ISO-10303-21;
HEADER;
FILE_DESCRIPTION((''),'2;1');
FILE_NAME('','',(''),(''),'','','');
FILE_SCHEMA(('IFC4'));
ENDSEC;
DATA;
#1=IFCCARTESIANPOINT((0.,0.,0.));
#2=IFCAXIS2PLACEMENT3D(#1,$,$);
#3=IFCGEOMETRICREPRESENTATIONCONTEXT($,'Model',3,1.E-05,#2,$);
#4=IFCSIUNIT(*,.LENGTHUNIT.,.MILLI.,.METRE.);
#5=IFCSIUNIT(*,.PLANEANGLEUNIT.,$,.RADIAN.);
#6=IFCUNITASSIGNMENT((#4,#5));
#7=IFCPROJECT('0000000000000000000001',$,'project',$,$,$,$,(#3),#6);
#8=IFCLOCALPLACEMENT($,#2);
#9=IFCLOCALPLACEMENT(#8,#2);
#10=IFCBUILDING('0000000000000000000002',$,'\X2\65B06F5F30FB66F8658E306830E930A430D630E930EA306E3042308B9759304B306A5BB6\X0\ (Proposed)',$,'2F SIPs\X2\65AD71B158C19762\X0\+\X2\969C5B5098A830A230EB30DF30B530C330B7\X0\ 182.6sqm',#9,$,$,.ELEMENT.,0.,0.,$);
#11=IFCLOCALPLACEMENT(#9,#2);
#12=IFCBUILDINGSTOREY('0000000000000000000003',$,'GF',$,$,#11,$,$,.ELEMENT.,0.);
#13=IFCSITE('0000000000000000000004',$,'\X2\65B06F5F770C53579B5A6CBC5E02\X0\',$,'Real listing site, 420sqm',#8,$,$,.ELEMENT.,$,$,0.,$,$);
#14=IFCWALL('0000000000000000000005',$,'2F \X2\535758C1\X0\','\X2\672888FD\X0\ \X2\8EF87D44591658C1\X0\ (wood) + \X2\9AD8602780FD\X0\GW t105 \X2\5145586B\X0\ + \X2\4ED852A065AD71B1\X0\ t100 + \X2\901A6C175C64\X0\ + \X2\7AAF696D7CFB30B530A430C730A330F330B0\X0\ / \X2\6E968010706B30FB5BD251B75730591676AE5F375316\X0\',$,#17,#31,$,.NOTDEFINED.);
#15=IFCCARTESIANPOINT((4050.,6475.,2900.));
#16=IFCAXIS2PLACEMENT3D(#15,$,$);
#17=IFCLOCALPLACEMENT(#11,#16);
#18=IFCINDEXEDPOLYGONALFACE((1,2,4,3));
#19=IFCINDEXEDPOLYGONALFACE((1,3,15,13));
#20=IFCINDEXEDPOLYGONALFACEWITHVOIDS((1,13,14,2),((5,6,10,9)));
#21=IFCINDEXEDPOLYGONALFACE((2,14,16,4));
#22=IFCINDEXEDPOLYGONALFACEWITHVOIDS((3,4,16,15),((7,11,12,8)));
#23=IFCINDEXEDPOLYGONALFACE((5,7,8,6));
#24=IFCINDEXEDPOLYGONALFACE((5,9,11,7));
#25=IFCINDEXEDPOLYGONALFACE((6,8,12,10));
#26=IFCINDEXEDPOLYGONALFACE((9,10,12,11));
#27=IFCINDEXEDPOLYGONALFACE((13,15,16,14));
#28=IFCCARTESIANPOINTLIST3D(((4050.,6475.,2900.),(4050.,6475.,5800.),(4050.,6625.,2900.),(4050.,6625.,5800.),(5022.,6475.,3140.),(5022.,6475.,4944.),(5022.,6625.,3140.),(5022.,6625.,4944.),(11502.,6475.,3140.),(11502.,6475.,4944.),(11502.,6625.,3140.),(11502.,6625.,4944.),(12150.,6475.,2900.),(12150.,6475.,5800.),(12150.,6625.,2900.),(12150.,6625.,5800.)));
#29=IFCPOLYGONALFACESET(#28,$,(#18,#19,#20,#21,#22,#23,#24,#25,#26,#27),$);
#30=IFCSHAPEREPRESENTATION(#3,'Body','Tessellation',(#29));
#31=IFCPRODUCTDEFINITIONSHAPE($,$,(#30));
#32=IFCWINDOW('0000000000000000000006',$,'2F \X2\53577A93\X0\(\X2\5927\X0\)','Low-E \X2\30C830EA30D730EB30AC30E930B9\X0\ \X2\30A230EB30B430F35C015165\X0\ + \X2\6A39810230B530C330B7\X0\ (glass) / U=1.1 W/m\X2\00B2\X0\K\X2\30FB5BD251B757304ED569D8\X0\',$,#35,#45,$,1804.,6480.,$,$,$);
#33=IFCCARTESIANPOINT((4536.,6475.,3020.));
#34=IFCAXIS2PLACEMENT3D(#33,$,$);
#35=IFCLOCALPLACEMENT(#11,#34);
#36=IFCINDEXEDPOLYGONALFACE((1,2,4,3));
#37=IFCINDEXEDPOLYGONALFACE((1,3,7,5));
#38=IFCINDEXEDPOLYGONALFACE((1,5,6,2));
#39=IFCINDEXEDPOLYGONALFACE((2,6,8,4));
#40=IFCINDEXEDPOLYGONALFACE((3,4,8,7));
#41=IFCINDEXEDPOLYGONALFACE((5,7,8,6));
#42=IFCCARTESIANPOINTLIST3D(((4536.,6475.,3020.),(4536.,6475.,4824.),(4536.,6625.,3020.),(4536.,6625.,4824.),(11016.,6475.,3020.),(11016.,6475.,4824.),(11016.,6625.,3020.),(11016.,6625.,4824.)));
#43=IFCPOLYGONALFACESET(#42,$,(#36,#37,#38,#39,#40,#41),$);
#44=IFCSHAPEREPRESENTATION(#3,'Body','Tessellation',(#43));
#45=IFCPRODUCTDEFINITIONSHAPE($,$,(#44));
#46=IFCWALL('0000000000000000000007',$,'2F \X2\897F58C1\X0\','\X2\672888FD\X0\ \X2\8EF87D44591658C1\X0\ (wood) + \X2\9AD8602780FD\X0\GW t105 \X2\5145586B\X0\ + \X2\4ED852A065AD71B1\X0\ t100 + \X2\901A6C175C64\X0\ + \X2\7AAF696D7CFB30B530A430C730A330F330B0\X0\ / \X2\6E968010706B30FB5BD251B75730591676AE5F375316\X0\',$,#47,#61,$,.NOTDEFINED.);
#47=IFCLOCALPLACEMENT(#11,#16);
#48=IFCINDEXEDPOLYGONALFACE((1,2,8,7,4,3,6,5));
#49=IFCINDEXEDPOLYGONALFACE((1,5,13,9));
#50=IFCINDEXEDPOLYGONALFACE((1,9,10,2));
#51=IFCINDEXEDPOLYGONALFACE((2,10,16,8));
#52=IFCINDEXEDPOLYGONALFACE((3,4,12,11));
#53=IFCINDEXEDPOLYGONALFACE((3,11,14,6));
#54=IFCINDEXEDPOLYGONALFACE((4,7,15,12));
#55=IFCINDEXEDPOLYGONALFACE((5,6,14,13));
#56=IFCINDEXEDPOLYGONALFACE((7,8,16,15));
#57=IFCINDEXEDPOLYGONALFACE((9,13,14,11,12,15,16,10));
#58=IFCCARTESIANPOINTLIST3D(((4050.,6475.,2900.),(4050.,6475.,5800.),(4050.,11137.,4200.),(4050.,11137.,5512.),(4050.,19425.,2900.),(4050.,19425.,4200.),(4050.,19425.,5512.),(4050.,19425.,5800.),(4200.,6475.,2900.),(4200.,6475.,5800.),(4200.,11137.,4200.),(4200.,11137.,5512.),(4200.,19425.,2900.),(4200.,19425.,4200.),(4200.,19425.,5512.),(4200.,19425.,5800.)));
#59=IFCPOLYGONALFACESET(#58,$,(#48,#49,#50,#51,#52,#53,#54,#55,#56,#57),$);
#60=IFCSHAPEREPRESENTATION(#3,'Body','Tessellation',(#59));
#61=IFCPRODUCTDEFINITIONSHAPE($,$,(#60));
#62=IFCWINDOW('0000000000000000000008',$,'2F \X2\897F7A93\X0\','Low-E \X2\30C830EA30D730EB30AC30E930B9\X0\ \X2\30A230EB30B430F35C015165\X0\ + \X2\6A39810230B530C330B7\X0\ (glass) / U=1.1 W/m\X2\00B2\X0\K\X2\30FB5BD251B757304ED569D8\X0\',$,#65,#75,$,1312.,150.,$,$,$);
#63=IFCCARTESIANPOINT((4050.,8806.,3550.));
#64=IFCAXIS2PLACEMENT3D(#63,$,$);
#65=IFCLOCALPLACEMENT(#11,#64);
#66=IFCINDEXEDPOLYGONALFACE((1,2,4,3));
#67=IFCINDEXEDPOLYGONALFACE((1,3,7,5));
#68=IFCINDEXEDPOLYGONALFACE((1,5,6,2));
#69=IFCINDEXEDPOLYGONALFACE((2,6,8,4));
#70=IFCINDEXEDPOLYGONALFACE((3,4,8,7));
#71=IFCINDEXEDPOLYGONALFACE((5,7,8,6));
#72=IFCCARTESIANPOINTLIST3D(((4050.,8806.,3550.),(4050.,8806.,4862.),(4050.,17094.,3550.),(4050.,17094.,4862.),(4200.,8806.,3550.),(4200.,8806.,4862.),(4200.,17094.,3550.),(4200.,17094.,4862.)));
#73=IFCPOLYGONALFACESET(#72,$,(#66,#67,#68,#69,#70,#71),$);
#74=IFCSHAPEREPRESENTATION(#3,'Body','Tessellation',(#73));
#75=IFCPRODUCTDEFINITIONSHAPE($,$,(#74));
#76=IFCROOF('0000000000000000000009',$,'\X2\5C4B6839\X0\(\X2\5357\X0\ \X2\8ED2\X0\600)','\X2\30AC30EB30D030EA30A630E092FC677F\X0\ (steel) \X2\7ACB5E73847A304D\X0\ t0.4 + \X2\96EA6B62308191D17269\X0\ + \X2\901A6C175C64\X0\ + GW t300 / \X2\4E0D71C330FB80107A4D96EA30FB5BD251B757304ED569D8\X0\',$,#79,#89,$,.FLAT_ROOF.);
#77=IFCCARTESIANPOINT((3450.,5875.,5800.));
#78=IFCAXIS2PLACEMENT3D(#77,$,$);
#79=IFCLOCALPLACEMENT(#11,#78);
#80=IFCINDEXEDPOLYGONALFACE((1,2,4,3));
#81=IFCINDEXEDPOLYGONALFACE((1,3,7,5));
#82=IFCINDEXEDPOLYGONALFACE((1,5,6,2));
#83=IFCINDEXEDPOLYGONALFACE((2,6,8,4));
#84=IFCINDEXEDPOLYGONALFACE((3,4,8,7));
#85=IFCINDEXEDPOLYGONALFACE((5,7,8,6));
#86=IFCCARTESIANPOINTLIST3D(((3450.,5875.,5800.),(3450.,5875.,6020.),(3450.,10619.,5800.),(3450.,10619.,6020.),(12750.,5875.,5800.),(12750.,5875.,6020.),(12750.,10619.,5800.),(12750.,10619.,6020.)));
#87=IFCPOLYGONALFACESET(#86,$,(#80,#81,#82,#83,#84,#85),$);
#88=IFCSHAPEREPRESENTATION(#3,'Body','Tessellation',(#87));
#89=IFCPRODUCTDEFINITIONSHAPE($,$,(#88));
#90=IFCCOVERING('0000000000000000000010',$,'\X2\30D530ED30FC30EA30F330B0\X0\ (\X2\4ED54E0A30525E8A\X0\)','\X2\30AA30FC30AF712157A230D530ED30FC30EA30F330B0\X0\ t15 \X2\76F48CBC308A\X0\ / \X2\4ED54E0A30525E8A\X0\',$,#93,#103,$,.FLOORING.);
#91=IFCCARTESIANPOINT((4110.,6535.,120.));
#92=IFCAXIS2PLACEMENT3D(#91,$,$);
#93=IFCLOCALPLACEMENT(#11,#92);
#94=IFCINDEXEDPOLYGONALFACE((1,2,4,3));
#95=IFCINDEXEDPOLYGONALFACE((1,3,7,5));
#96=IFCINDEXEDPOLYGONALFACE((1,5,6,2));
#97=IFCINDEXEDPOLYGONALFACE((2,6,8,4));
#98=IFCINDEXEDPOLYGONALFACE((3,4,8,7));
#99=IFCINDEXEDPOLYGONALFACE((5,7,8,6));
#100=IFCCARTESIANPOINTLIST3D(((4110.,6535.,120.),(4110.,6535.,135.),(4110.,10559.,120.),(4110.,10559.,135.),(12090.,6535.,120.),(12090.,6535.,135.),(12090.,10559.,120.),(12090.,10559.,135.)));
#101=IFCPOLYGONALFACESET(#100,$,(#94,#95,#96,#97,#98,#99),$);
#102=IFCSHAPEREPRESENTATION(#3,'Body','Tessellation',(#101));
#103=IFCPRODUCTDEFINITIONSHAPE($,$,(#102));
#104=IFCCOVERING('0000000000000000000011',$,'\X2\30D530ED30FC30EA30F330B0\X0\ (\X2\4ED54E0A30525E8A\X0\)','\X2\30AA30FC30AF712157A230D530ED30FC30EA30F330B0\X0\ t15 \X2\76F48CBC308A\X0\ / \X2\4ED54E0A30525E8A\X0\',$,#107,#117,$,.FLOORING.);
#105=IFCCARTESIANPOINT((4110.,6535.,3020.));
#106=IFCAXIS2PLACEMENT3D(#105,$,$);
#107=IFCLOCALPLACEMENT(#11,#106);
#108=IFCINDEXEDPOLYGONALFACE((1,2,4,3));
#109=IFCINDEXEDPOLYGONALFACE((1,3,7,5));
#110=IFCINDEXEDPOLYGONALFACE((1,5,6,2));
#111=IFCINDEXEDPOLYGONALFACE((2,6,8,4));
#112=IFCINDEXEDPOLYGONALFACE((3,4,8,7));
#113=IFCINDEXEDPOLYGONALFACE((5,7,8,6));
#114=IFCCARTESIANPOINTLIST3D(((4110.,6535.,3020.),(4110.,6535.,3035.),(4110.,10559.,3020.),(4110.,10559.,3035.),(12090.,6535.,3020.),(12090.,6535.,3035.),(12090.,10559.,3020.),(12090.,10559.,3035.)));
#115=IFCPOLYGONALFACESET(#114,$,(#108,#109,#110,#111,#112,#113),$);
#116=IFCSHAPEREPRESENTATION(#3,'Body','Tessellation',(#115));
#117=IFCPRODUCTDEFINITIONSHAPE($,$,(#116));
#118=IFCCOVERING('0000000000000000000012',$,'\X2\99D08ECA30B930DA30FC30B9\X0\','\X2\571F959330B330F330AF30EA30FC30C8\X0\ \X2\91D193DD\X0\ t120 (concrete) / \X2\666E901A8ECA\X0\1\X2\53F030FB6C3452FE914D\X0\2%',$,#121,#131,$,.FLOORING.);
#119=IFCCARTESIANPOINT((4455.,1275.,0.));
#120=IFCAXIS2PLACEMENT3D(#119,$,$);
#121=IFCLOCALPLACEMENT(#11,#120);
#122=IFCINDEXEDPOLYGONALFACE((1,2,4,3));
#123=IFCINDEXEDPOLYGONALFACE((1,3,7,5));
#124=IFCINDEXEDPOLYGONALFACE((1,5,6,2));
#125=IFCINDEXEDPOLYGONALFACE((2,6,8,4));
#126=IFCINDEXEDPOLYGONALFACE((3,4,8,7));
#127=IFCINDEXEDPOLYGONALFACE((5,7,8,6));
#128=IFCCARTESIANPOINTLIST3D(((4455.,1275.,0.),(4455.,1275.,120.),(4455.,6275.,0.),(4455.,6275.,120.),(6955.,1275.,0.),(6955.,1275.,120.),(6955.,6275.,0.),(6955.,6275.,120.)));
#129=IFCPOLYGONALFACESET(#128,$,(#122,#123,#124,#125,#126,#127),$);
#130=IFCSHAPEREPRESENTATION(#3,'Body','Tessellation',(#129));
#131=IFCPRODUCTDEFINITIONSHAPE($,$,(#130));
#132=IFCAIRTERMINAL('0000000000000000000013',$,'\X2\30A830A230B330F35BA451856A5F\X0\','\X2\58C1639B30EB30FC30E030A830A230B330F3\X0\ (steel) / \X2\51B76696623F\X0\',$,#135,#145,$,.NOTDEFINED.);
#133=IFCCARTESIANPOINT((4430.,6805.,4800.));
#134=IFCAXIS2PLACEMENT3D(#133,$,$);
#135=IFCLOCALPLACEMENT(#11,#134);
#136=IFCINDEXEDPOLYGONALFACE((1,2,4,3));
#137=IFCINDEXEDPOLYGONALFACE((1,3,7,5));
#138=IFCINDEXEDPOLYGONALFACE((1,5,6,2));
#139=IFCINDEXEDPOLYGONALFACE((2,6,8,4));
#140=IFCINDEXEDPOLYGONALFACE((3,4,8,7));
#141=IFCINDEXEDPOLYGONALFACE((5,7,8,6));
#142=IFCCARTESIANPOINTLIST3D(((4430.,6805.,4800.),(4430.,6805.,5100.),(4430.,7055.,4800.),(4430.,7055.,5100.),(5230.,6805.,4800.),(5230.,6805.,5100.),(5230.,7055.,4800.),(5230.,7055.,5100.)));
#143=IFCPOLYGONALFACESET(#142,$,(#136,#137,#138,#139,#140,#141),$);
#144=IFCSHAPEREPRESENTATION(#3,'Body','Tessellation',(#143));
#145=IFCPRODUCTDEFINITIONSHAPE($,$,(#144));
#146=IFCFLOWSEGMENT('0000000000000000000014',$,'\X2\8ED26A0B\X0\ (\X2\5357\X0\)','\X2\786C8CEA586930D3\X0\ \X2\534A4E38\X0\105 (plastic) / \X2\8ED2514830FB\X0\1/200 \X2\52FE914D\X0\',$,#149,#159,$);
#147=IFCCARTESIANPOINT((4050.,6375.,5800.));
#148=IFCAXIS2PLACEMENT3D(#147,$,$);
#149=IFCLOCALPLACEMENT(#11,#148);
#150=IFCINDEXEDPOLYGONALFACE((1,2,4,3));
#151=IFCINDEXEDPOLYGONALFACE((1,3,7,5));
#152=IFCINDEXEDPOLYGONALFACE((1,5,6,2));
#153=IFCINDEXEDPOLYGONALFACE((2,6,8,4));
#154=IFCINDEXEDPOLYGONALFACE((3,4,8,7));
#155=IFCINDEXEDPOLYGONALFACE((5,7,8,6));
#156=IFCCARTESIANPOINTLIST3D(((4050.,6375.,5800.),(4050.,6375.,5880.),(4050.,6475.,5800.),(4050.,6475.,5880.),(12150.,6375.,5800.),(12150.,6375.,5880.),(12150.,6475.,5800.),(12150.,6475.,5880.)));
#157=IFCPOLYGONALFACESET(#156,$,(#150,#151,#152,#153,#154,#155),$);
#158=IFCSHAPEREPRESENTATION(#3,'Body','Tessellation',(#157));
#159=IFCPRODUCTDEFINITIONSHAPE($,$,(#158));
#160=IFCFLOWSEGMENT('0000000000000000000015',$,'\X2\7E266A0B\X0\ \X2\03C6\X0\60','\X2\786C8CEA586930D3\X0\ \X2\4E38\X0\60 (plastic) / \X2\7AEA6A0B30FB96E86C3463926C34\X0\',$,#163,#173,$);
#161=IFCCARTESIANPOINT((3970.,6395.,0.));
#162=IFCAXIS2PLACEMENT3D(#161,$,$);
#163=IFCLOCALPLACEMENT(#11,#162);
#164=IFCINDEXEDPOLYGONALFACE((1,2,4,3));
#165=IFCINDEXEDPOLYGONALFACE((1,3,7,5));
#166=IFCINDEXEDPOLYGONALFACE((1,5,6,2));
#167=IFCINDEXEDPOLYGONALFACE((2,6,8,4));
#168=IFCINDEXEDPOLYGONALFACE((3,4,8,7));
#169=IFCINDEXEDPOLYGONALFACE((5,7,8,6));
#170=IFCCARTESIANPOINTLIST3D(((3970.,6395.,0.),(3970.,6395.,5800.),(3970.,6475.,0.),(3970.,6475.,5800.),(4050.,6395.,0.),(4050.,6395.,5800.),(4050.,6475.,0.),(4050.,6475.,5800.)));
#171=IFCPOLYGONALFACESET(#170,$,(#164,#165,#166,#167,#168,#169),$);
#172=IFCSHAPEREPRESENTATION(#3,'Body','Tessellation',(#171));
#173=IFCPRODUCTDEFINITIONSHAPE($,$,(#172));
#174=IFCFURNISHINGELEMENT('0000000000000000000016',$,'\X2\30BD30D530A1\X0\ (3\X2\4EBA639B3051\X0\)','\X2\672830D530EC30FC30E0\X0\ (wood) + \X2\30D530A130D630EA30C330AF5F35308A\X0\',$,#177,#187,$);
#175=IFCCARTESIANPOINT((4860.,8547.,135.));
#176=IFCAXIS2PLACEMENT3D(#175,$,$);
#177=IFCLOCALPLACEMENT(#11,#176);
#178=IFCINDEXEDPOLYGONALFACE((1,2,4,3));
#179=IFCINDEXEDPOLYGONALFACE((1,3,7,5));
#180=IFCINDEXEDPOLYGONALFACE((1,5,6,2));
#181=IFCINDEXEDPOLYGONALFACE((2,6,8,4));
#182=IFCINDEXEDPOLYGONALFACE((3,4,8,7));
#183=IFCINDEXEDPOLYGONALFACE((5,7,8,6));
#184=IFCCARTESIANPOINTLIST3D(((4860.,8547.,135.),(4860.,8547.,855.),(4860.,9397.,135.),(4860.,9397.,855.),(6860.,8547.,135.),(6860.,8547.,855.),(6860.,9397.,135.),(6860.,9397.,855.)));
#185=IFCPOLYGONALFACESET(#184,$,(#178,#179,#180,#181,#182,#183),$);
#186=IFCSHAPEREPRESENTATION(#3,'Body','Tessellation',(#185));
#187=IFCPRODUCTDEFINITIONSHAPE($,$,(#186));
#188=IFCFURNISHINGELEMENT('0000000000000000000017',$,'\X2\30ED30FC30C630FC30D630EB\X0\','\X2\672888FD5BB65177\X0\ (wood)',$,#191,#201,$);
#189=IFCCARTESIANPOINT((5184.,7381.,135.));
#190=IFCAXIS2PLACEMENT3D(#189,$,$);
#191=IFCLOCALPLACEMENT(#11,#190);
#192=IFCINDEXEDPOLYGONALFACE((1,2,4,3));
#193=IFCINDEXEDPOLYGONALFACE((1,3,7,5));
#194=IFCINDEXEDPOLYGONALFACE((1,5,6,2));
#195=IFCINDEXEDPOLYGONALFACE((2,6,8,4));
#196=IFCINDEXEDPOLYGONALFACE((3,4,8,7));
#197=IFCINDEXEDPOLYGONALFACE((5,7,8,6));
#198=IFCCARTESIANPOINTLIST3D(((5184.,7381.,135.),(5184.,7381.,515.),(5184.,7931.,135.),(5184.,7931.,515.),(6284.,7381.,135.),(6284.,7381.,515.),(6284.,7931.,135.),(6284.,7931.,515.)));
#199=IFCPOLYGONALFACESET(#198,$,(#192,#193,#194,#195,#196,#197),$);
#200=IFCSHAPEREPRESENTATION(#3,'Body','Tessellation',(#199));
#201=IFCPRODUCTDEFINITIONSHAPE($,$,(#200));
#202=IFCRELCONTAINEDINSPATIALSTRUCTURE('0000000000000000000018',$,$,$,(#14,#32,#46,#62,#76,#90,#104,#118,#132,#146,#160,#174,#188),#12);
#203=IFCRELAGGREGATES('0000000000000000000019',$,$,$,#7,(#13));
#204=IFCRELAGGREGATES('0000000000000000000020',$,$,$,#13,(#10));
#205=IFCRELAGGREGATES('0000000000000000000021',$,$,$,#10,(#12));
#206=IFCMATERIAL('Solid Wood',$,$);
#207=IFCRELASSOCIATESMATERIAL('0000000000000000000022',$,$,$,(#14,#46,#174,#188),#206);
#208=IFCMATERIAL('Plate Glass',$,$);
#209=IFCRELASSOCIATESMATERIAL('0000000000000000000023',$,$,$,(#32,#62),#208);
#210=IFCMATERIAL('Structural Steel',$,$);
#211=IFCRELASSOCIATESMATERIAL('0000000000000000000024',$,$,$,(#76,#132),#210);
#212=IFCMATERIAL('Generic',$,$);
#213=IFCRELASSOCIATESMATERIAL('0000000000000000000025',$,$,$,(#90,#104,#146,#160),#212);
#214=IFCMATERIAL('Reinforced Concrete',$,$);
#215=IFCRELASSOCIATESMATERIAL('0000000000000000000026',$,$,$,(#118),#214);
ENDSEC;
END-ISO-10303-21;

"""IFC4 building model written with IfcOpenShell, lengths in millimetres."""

from ifc_helpers import new_model, si_unit, frame, frame_2d, origin, place, context, project, spatial, rectangle, extrude, material, element, fill, save


model = new_model("IFC4")

# Units and contexts
model_context = context("Model", 3, precision=1e-05, world=origin())
ifc_project = project(units=[si_unit("LENGTHUNIT", "METRE", prefix="MILLI"), si_unit("PLANEANGLEUNIT", "RADIAN")], contexts=[model_context])

# Site, building, storey
site_placement = place(None, origin())
site = spatial("IfcSite", under=ifc_project, at=site_placement, Name="新潟県南魚沼市", ObjectType="Real listing site, 420sqm", CompositionType="ELEMENT", RefElevation=0.0)
building_placement = place(site_placement, origin())
building = spatial("IfcBuilding", under=site, at=building_placement, Name="新潟・書斎とライブラリのある静かな家 (Proposed)", ObjectType="2F SIPs断熱壁面+障子風アルミサッシ 182.6sqm", CompositionType="ELEMENT", ElevationOfRefHeight=0.0, ElevationOfTerrain=0.0)
storey_placement = place(building_placement, origin())
storey = spatial("IfcBuildingStorey", under=building, at=storey_placement, Name="GF", CompositionType="ELEMENT", Elevation=0.0)

# Shared definitions
ifc_material_1 = material(Name="Solid Wood")

# Shared definitions
ifc_material_2 = material(Name="Reinforced Concrete")

# Shared definitions
ifc_material_3 = material(Name="Plate Glass")

# Walls, openings, windows
wall_1_placement = place(storey_placement, frame((4050.0, 6475.0, 2900.0)))
wall_1 = element("IfcWall", 1, at=wall_1_placement, inside=storey, material=ifc_material_1, Name="2F 南壁", Description="木製 軸組外壁 (wood) + 高性能GW t105 充填 + 付加断熱 t100 + 通気層 + 窯業系サイディング / 準耐火・寒冷地外皮強化", PredefinedType="NOTDEFINED", context=model_context, shape_type="SweptSolid", body=[
    extrude(rectangle(XDim=8100.0, YDim=150.0, at=frame_2d((4050.0, 75.0))), frame((4050.0, 6475.0, 2900.0)), (0.0, 0.0, 1.0), 2900.0),
])
opening_1_placement = place(storey_placement, frame((4536.0, 6475.0, 3020.0)))
opening_1 = element("IfcOpeningElement", 2, at=opening_1_placement, cuts=wall_1, PredefinedType="NOTDEFINED", context=model_context, shape_type="SweptSolid", body=[
    extrude(rectangle(XDim=6480.0, YDim=150.0, at=frame_2d((3240.0, 75.0))), frame((4536.0, 6475.0, 3020.0)), (0.0, 0.0, 1.0), 1804.0),
])
window_1_placement = place(storey_placement, frame((4536.0, 6475.0, 3020.0)))
window_1 = element("IfcWindow", 3, at=window_1_placement, inside=storey, material=ifc_material_3, Name="2F 南窓(大)", Description="Low-E トリプルガラス アルゴン封入 + 樹脂サッシ (glass) / U=1.1 W/m²K・寒冷地仕様", OverallHeight=1804.0, OverallWidth=6480.0, context=model_context, shape_type="SweptSolid", body=[
    extrude(rectangle(XDim=6480.0, YDim=150.0, at=frame_2d((3240.0, 75.0))), frame((4536.0, 6475.0, 3020.0)), (0.0, 0.0, 1.0), 1804.0),
])
fill(opening_1, window_1)
wall_2_placement = place(storey_placement, frame((4050.0, 6475.0, 2900.0)))
wall_2 = element("IfcWall", 4, at=wall_2_placement, inside=storey, material=ifc_material_1, Name="2F 西壁", Description="木製 軸組外壁 (wood) + 高性能GW t105 充填 + 付加断熱 t100 + 通気層 + 窯業系サイディング / 準耐火・寒冷地外皮強化", PredefinedType="NOTDEFINED", context=model_context, shape_type="SweptSolid", body=[
    extrude(rectangle(XDim=150.0, YDim=12950.0, at=frame_2d((75.0, 6475.0))), frame((4050.0, 6475.0, 2900.0)), (0.0, 0.0, 1.0), 2900.0),
])
opening_2_placement = place(storey_placement, frame((4050.0, 8806.0, 3550.0)))
opening_2 = element("IfcOpeningElement", 5, at=opening_2_placement, cuts=wall_2, PredefinedType="NOTDEFINED", context=model_context, shape_type="SweptSolid", body=[
    extrude(rectangle(XDim=150.0, YDim=8288.0, at=frame_2d((75.0, 4144.0))), frame((4050.0, 8806.0, 3550.0)), (0.0, 0.0, 1.0), 1312.0),
])
window_2_placement = place(storey_placement, frame((4050.0, 8806.0, 3550.0)))
window_2 = element("IfcWindow", 6, at=window_2_placement, inside=storey, material=ifc_material_3, Name="2F 西窓", Description="Low-E トリプルガラス アルゴン封入 + 樹脂サッシ (glass) / U=1.1 W/m²K・寒冷地仕様", OverallHeight=1312.0, OverallWidth=150.0, context=model_context, shape_type="SweptSolid", body=[
    extrude(rectangle(XDim=150.0, YDim=8288.0, at=frame_2d((75.0, 4144.0))), frame((4050.0, 8806.0, 3550.0)), (0.0, 0.0, 1.0), 1312.0),
])
fill(opening_2, window_2)

# Roof
ifc_material_4 = material(Name="Structural Steel")
for number, where, name in (
    (7, (3450.0, 5875.0, 5800.0), "屋根(南 軒600)"),
):
    element("IfcRoof", number, at=place(storey_placement, frame(where)), inside=storey, material=ifc_material_4, Name=name, Description="ガルバリウム鋼板 (steel) 立平葺き t0.4 + 雪止め金物 + 通気層 + GW t300 / 不燃・耐積雪・寒冷地仕様", PredefinedType="FLAT_ROOF", context=model_context, shape_type="SweptSolid", body=[
        extrude(rectangle(XDim=9300.0, YDim=4744.0, at=frame_2d((4650.0, 2372.0))), frame((3450.0, 5875.0, 5800.0)), (0.0, 0.0, 1.0), 220.0),
    ])

# Coverings
ifc_material_5 = material(Name="Generic")
covering_1_placement = place(storey_placement, frame((4110.0, 6535.0, 120.0)))
element("IfcCovering", 8, at=covering_1_placement, inside=storey, material=ifc_material_5, Name="フローリング (仕上げ床)", Description="オーク無垢フローリング t15 直貼り / 仕上げ床", PredefinedType="FLOORING", context=model_context, shape_type="SweptSolid", body=[
    extrude(rectangle(XDim=7980.0, YDim=4024.0, at=frame_2d((3990.0, 2012.0))), frame((4110.0, 6535.0, 120.0)), (0.0, 0.0, 1.0), 15.0),
])
covering_2_placement = place(storey_placement, frame((4110.0, 6535.0, 3020.0)))
element("IfcCovering", 9, at=covering_2_placement, inside=storey, material=ifc_material_5, Name="フローリング (仕上げ床)", Description="オーク無垢フローリング t15 直貼り / 仕上げ床", PredefinedType="FLOORING", context=model_context, shape_type="SweptSolid", body=[
    extrude(rectangle(XDim=7980.0, YDim=4024.0, at=frame_2d((3990.0, 2012.0))), frame((4110.0, 6535.0, 3020.0)), (0.0, 0.0, 1.0), 15.0),
])
covering_3_placement = place(storey_placement, frame((4455.0, 1275.0, 0.0)))
element("IfcCovering", 10, at=covering_3_placement, inside=storey, material=ifc_material_2, Name="駐車スペース", Description="土間コンクリート 金鏝 t120 (concrete) / 普通車1台・水勾配2%", PredefinedType="FLOORING", context=model_context, shape_type="SweptSolid", body=[
    extrude(rectangle(XDim=2500.0, YDim=5000.0, at=frame_2d((1250.0, 2500.0))), frame((4455.0, 1275.0, 0.0)), (0.0, 0.0, 1.0), 120.0),
])

# Air terminal
air_terminal_placement = place(storey_placement, frame((4430.0, 6805.0, 4800.0)))
element("IfcAirTerminal", 11, at=air_terminal_placement, inside=storey, material=ifc_material_4, Name="エアコン室内機", Description="壁掛ルームエアコン (steel) / 冷暖房", PredefinedType="NOTDEFINED", context=model_context, shape_type="SweptSolid", body=[
    extrude(rectangle(XDim=800.0, YDim=250.0, at=frame_2d((400.0, 125.0))), frame((4430.0, 6805.0, 4800.0)), (0.0, 0.0, 1.0), 300.0),
])

# Flow segments
flow_segment_1_placement = place(storey_placement, frame((4050.0, 6375.0, 5800.0)))
element("IfcFlowSegment", 12, at=flow_segment_1_placement, inside=storey, material=ifc_material_5, Name="軒樋 (南)", Description="硬質塩ビ 半丸105 (plastic) / 軒先・1/200 勾配", context=model_context, shape_type="SweptSolid", body=[
    extrude(rectangle(XDim=8100.0, YDim=100.0, at=frame_2d((4050.0, 50.0))), frame((4050.0, 6375.0, 5800.0)), (0.0, 0.0, 1.0), 80.0),
])
flow_segment_2_placement = place(storey_placement, frame((3970.0, 6395.0, 0.0)))
element("IfcFlowSegment", 13, at=flow_segment_2_placement, inside=storey, material=ifc_material_5, Name="縦樋 φ60", Description="硬質塩ビ 丸60 (plastic) / 竪樋・雨水排水", context=model_context, shape_type="SweptSolid", body=[
    extrude(rectangle(XDim=80.0, YDim=80.0, at=frame_2d((40.0, 40.0))), frame((3970.0, 6395.0, 0.0)), (0.0, 0.0, 1.0), 5800.0),
])

# Furnishing elements
furnishing_1_placement = place(storey_placement, frame((4860.0, 8547.0, 135.0)))
element("IfcFurnishingElement", 14, at=furnishing_1_placement, inside=storey, material=ifc_material_1, Name="ソファ (3人掛け)", Description="木フレーム (wood) + ファブリック張り", context=model_context, shape_type="SweptSolid", body=[
    extrude(rectangle(XDim=2000.0, YDim=850.0, at=frame_2d((1000.0, 425.0))), frame((4860.0, 8547.0, 135.0)), (0.0, 0.0, 1.0), 720.0),
])
furnishing_2_placement = place(storey_placement, frame((5184.0, 7381.0, 135.0)))
element("IfcFurnishingElement", 15, at=furnishing_2_placement, inside=storey, material=ifc_material_1, Name="ローテーブル", Description="木製家具 (wood)", context=model_context, shape_type="SweptSolid", body=[
    extrude(rectangle(XDim=1100.0, YDim=550.0, at=frame_2d((550.0, 275.0))), frame((5184.0, 7381.0, 135.0)), (0.0, 0.0, 1.0), 380.0),
])

save(model, "model.ifc")
